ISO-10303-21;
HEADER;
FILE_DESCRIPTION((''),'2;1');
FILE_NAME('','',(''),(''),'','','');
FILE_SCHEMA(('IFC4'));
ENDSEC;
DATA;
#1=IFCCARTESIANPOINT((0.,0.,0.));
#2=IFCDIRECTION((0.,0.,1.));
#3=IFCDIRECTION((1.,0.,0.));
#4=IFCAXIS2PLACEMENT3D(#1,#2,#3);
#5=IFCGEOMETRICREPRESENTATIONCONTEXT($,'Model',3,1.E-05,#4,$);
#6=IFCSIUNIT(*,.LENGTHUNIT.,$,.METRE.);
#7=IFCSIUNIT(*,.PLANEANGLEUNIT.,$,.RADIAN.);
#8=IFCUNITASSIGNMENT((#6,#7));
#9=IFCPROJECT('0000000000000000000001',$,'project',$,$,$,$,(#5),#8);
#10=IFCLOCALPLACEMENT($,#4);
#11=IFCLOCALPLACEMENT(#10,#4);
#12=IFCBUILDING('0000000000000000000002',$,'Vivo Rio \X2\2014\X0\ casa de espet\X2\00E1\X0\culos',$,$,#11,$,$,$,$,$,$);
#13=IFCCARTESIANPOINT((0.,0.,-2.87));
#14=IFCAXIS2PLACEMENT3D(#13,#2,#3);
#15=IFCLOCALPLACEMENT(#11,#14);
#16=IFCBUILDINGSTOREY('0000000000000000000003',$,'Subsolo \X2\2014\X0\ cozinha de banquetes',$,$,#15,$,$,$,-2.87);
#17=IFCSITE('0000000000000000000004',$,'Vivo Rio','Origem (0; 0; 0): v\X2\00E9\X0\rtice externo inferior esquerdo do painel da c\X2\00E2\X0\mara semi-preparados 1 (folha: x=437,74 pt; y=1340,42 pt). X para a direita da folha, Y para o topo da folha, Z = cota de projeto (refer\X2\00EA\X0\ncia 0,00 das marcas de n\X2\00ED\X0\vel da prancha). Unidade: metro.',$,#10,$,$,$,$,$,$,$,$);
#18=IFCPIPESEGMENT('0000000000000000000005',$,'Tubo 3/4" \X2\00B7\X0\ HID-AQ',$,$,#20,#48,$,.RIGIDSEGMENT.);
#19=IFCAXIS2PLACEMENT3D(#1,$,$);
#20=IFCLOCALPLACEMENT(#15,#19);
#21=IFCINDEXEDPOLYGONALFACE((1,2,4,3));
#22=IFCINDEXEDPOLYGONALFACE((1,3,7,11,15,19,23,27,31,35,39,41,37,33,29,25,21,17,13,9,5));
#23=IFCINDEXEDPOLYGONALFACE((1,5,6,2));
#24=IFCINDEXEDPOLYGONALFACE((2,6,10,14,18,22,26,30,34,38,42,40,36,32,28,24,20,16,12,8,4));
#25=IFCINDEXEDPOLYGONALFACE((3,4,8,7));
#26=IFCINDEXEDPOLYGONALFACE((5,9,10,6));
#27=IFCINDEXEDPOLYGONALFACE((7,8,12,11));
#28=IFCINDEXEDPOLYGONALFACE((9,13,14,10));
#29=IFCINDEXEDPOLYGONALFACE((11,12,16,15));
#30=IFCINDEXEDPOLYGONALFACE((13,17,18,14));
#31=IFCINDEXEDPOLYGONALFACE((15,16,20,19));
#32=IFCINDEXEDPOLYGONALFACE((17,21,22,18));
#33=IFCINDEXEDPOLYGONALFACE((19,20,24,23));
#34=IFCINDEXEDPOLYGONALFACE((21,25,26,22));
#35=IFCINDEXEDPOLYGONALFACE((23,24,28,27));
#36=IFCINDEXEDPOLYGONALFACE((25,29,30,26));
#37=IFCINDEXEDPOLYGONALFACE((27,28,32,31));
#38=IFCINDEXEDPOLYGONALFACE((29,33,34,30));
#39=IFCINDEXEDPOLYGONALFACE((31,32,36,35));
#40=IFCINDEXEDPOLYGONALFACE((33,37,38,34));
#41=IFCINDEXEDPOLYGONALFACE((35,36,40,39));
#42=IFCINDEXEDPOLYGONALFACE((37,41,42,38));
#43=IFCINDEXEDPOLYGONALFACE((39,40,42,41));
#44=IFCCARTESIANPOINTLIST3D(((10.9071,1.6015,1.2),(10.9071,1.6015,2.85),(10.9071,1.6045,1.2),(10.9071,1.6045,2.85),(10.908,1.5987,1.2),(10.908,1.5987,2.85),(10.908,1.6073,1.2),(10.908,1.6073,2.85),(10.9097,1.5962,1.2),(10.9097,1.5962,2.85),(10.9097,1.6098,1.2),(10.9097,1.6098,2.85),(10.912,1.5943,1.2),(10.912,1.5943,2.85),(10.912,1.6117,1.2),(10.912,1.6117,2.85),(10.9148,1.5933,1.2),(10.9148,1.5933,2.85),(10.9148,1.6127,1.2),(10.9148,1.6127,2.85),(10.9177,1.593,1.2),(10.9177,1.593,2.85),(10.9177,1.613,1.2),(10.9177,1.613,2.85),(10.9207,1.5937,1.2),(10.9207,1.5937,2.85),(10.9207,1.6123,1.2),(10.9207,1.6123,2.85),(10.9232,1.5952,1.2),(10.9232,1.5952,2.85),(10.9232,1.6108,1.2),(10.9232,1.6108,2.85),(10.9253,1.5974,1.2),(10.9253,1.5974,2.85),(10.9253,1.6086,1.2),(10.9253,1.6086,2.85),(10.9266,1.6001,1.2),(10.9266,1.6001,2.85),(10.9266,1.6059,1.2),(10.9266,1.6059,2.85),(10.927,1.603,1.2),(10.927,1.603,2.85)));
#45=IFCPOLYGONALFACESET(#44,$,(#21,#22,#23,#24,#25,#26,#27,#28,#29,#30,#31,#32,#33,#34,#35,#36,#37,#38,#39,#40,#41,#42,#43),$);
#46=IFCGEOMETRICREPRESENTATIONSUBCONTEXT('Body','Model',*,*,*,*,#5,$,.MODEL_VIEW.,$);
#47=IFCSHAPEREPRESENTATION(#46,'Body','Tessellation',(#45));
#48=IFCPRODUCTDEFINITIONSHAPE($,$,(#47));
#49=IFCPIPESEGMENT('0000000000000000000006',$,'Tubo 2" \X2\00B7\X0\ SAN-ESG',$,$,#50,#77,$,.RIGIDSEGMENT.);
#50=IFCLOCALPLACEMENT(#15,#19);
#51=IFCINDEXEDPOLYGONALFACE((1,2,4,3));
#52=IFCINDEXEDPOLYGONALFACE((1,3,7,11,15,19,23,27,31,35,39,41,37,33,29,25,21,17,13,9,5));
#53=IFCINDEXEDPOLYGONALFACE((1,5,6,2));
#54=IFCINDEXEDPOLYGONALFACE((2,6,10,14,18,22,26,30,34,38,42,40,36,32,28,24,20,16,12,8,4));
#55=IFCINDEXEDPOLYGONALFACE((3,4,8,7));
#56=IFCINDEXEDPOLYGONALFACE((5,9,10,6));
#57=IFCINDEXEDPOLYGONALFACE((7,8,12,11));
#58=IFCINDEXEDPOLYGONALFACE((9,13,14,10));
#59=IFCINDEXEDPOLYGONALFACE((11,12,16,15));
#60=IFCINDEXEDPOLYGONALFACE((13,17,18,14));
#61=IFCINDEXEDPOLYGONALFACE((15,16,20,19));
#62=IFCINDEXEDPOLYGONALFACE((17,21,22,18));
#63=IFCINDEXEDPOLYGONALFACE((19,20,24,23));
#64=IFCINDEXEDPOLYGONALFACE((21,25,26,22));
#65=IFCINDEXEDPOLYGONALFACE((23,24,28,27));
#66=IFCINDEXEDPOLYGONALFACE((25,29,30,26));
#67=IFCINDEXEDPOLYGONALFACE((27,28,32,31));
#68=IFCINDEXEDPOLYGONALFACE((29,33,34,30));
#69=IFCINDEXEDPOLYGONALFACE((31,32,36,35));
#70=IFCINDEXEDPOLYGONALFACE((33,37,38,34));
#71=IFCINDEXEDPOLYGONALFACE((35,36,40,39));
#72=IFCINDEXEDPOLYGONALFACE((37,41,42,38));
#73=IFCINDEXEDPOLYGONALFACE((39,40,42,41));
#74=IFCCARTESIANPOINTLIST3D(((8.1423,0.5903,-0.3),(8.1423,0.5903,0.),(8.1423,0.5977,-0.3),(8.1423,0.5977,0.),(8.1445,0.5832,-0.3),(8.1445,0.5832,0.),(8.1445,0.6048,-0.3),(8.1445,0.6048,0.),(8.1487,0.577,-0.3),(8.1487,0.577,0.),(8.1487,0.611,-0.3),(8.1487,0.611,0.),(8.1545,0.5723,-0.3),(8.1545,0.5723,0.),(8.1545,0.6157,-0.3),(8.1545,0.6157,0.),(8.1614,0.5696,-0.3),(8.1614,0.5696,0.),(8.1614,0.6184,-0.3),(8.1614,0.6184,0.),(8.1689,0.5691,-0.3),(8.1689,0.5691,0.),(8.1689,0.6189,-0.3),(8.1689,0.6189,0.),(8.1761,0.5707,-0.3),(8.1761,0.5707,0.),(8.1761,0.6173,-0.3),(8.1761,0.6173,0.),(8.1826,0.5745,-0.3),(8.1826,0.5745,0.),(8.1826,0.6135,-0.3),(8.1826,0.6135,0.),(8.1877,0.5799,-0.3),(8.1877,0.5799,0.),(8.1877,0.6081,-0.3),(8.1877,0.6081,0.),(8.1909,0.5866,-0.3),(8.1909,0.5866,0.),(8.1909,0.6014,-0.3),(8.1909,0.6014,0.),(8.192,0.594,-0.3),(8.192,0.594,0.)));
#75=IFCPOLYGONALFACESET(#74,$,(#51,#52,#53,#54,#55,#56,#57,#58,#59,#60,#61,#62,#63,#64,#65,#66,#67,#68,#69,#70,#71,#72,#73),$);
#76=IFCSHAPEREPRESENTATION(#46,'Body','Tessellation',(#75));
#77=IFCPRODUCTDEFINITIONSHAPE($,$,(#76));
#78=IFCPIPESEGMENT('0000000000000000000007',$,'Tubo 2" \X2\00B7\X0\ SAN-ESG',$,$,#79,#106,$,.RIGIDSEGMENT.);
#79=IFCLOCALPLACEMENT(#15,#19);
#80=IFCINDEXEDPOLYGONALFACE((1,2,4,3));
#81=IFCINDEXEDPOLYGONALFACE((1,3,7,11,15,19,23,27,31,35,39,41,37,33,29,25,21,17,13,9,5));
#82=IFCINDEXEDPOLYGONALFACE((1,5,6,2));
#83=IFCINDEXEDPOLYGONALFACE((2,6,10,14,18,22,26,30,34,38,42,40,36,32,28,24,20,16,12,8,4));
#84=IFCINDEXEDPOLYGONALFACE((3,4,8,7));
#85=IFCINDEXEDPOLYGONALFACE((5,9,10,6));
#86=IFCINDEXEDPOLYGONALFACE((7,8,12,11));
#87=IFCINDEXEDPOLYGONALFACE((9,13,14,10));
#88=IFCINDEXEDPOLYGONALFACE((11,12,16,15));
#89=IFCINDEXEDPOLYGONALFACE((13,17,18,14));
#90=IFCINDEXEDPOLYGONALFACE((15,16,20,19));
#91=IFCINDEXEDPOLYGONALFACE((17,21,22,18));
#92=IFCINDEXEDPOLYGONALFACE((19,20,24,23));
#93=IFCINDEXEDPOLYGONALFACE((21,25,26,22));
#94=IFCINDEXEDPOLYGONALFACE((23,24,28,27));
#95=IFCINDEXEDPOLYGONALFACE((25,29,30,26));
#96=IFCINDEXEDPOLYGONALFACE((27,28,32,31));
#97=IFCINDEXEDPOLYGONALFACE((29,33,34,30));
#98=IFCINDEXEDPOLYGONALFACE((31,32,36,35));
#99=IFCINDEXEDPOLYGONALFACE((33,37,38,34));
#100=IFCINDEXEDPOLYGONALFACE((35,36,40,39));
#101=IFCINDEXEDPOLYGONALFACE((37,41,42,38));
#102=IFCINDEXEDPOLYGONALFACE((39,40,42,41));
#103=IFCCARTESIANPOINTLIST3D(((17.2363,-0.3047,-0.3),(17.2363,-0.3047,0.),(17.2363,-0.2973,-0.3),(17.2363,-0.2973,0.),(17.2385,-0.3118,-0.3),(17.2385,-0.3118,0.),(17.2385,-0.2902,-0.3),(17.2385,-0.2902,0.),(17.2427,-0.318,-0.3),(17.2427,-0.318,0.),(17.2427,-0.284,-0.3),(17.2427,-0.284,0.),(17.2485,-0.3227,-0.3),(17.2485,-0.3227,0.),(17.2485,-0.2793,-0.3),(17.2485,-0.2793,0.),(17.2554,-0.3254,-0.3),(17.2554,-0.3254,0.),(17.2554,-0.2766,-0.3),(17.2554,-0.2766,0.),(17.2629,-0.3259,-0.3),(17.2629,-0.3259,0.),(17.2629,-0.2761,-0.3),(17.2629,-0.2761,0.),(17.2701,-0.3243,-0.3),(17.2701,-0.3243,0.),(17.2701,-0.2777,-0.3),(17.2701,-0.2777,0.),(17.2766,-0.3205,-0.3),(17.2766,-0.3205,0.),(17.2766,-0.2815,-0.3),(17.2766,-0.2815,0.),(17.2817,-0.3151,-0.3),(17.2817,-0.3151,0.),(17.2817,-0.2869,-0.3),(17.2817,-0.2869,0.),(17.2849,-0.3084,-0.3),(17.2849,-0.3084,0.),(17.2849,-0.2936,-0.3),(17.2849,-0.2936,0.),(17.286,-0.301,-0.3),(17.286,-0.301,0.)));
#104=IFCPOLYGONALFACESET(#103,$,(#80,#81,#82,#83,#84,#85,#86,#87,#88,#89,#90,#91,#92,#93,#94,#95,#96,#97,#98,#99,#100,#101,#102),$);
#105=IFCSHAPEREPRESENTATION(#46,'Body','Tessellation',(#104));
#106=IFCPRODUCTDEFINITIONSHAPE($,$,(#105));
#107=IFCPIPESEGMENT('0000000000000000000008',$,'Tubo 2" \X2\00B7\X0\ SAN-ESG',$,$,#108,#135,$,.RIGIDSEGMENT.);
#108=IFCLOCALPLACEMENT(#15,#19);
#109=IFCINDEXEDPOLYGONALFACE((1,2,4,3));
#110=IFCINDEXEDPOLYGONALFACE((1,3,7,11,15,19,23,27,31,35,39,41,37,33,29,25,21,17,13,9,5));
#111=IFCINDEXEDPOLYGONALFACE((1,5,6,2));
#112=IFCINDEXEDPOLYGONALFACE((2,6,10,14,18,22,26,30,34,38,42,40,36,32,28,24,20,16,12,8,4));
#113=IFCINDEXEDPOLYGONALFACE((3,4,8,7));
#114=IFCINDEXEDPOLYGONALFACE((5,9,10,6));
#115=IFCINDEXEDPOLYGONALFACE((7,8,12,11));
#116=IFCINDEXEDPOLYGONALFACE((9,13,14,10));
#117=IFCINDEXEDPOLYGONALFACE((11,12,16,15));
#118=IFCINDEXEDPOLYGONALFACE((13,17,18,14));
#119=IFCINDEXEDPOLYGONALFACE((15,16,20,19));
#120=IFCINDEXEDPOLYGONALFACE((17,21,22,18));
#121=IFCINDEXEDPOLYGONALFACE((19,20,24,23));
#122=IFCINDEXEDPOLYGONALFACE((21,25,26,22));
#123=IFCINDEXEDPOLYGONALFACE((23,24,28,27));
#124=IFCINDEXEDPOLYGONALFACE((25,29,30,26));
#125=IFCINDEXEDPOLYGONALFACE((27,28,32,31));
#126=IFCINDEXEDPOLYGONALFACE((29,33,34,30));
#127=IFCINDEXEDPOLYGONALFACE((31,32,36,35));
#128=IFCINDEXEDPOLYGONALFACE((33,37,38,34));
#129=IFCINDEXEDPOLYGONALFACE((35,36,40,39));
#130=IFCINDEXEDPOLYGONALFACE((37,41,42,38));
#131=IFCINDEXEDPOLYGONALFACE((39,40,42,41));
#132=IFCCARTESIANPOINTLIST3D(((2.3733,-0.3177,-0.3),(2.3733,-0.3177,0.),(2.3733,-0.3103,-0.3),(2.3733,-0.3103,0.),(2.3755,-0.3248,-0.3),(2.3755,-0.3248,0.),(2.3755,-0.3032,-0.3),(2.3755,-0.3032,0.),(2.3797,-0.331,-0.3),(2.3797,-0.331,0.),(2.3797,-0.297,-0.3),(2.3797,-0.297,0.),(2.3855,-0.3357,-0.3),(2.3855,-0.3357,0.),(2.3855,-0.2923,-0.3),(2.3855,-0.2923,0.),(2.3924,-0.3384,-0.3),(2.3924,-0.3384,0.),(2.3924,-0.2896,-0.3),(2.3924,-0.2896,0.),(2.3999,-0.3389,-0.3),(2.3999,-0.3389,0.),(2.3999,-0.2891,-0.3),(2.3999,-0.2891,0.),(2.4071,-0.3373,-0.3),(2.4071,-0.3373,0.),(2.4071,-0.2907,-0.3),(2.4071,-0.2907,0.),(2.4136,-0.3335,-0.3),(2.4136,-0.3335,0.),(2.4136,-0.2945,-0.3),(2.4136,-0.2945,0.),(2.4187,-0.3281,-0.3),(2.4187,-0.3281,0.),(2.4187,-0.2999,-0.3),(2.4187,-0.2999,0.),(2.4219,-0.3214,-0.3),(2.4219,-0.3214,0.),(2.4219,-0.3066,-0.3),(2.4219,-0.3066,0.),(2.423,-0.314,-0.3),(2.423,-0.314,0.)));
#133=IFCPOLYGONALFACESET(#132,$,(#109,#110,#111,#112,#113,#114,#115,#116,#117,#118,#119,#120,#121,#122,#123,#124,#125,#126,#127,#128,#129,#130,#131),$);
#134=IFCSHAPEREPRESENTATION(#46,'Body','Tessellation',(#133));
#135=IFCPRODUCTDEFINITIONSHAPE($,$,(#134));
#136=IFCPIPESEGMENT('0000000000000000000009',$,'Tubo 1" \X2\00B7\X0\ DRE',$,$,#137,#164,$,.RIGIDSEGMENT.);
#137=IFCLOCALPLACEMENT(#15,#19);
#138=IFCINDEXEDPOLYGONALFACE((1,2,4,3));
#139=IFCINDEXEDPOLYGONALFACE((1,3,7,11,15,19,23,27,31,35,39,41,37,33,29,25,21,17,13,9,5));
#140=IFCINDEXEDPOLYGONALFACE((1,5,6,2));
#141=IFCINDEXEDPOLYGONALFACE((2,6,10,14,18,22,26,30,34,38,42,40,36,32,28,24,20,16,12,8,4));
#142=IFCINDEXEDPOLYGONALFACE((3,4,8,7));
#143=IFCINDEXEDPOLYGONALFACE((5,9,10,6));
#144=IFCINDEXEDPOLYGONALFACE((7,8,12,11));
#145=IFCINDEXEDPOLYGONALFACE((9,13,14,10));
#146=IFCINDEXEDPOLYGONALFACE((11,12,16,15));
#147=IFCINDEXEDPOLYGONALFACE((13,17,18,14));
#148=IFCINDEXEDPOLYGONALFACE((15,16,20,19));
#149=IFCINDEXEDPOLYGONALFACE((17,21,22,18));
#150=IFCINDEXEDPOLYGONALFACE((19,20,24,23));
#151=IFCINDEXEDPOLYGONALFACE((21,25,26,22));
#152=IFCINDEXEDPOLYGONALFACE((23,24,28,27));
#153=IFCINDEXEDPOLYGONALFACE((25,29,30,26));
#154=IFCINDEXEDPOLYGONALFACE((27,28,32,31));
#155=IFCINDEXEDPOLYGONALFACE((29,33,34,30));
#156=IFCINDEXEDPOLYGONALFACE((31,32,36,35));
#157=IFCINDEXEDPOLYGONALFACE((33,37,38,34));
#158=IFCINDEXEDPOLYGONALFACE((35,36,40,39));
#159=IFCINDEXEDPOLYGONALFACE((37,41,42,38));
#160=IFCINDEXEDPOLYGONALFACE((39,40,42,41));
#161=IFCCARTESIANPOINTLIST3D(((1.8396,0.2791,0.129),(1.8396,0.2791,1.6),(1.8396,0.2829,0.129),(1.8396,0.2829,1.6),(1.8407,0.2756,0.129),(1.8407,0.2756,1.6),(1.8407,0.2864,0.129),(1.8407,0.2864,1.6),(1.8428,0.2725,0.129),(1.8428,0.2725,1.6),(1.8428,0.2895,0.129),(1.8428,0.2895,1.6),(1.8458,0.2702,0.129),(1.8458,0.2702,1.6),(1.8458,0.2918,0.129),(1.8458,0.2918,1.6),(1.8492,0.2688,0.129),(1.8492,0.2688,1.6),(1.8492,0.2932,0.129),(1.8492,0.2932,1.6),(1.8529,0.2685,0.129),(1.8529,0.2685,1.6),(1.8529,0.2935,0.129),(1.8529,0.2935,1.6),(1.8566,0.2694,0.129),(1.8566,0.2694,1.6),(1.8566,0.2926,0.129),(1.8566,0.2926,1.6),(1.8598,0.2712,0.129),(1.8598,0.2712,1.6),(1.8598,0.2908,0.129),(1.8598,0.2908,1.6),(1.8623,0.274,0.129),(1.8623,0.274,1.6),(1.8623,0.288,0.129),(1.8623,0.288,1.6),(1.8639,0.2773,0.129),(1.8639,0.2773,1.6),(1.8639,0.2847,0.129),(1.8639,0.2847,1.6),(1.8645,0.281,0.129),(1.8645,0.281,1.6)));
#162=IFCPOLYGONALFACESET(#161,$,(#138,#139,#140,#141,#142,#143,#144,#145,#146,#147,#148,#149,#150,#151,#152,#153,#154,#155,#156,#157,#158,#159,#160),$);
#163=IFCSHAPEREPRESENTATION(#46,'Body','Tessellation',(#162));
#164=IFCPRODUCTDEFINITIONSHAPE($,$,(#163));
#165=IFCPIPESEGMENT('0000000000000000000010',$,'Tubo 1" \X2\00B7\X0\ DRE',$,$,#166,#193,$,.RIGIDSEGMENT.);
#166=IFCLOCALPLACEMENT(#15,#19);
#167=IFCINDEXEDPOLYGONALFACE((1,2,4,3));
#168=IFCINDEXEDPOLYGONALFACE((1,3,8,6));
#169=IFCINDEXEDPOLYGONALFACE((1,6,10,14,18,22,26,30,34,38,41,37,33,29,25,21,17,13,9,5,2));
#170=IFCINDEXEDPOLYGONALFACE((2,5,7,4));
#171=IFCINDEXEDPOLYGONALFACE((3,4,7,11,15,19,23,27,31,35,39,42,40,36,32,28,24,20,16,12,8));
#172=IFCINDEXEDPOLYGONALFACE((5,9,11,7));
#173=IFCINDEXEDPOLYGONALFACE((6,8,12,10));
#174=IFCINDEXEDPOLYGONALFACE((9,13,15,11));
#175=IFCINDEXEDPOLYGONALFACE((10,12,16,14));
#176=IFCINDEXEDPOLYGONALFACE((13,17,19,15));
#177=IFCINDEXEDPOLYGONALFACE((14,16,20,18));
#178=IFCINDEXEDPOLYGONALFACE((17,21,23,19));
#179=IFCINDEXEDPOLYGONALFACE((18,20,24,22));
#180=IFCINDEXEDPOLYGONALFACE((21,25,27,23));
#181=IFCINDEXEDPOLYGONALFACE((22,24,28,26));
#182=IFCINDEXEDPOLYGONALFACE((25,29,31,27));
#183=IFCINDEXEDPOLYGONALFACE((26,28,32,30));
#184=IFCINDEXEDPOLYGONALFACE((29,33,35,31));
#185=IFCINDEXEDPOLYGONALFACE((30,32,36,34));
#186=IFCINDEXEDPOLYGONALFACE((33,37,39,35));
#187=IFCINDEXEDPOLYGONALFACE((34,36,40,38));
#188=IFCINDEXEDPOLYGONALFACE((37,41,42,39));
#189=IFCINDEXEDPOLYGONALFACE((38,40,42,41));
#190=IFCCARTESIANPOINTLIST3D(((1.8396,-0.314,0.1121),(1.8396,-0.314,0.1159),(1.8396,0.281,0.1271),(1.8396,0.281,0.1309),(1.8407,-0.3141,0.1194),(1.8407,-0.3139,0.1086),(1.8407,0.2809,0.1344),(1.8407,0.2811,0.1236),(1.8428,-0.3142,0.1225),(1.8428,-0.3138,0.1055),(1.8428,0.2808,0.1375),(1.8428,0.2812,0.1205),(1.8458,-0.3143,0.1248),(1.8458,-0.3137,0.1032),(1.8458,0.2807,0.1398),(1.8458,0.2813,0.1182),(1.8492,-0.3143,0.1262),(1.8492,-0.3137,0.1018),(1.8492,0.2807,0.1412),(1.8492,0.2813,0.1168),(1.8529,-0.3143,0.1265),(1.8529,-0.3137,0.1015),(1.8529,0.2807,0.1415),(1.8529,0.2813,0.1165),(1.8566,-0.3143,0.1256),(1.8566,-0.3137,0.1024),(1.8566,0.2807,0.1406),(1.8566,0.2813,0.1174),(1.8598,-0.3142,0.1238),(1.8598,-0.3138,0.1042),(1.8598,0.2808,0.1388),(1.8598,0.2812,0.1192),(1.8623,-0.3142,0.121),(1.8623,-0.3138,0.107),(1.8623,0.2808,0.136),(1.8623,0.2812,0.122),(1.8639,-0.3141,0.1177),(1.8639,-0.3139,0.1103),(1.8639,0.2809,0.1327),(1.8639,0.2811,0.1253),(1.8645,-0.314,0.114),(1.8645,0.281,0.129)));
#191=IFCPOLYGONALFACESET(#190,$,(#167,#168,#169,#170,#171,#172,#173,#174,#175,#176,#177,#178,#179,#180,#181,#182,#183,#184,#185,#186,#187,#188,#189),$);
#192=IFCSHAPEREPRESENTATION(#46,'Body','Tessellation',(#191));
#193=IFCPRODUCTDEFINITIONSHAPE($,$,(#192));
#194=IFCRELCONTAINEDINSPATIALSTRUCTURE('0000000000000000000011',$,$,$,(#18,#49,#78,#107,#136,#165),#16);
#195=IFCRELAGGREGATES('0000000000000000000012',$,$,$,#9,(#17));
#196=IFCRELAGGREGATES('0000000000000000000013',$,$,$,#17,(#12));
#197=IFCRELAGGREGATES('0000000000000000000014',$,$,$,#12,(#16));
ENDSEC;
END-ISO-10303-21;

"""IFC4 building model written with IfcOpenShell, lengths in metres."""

from ifc_helpers import new_model, si_unit, frame, origin_with_axes, origin_2d, place, context, subcontext, project, spatial, circle, extrude, element, save


model = new_model("IFC4")

# Units and contexts
model_context = context("Model", 3, precision=1e-05, world=origin_with_axes())
body_context = subcontext(model_context, "Body", "Model", "MODEL_VIEW")
ifc_project = project(units=[si_unit("LENGTHUNIT", "METRE"), si_unit("PLANEANGLEUNIT", "RADIAN")], contexts=[model_context])

# Site, building, storey
site_placement = place(None, origin_with_axes())
site = spatial("IfcSite", under=ifc_project, at=site_placement, Name="Vivo Rio", Description="Origem (0; 0; 0): vértice externo inferior esquerdo do painel da câmara semi-preparados 1 (folha: x=437,74 pt; y=1340,42 pt). X para a direita da folha, Y para o topo da folha, Z = cota de projeto (referência 0,00 das marcas de nível da prancha). Unidade: metro.")
building_placement = place(site_placement, origin_with_axes())
building = spatial("IfcBuilding", under=site, at=building_placement, Name="Vivo Rio — casa de espetáculos")
storey_placement = place(building_placement, frame((0.0, 0.0, -2.87), z_axis=(0.0, 0.0, 1.0), x_axis=(1.0, 0.0, 0.0)))
storey = spatial("IfcBuildingStorey", under=building, at=storey_placement, Name="Subsolo — cozinha de banquetes", Elevation=-2.87)

# Pipe segments
pipe_segment_1_placement = place(storey_placement, origin_with_axes())
element("IfcPipeSegment", 1, at=pipe_segment_1_placement, inside=storey, Name="Tubo 3/4\" · HID-AQ", PredefinedType="RIGIDSEGMENT", context=body_context, shape_type="SweptSolid", body=[
    extrude(circle(Radius=0.01, at=origin_2d()), frame((10.917, 1.603, 2.85), z_axis=(0.0, 0.0, -1.0), x_axis=(1.0, 0.0, 0.0)), (0.0, 0.0, 1.0), 1.65),
])
pipe_segment_2_placement = place(storey_placement, origin_with_axes())
element("IfcPipeSegment", 2, at=pipe_segment_2_placement, inside=storey, Name="Tubo 2\" · SAN-ESG", PredefinedType="RIGIDSEGMENT", context=body_context, shape_type="SweptSolid", body=[
    extrude(circle(Radius=0.025, at=origin_2d()), frame((8.167, 0.594, 0.0), z_axis=(0.0, 0.0, -1.0), x_axis=(1.0, 0.0, 0.0)), (0.0, 0.0, 1.0), 0.3),
])
pipe_segment_3_placement = place(storey_placement, origin_with_axes())
element("IfcPipeSegment", 3, at=pipe_segment_3_placement, inside=storey, Name="Tubo 2\" · SAN-ESG", PredefinedType="RIGIDSEGMENT", context=body_context, shape_type="SweptSolid", body=[
    extrude(circle(Radius=0.025, at=origin_2d()), frame((17.261, -0.301, 0.0), z_axis=(0.0, 0.0, -1.0), x_axis=(1.0, 0.0, 0.0)), (0.0, 0.0, 1.0), 0.3),
])
pipe_segment_4_placement = place(storey_placement, origin_with_axes())
element("IfcPipeSegment", 4, at=pipe_segment_4_placement, inside=storey, Name="Tubo 2\" · SAN-ESG", PredefinedType="RIGIDSEGMENT", context=body_context, shape_type="SweptSolid", body=[
    extrude(circle(Radius=0.025, at=origin_2d()), frame((2.398, -0.314, 0.0), z_axis=(0.0, 0.0, -1.0), x_axis=(1.0, 0.0, 0.0)), (0.0, 0.0, 1.0), 0.3),
])
pipe_segment_5_placement = place(storey_placement, origin_with_axes())
element("IfcPipeSegment", 5, at=pipe_segment_5_placement, inside=storey, Name="Tubo 1\" · DRE", PredefinedType="RIGIDSEGMENT", context=body_context, shape_type="SweptSolid", body=[
    extrude(circle(Radius=0.0125, at=origin_2d()), frame((1.852, 0.281, 1.6), z_axis=(0.0, 0.0, -1.0), x_axis=(1.0, 0.0, 0.0)), (0.0, 0.0, 1.0), 1.471),
])
pipe_segment_6_placement = place(storey_placement, origin_with_axes())
element("IfcPipeSegment", 6, at=pipe_segment_6_placement, inside=storey, Name="Tubo 1\" · DRE", PredefinedType="RIGIDSEGMENT", context=body_context, shape_type="SweptSolid", body=[
    extrude(circle(Radius=0.0125, at=origin_2d()), frame((1.852, 0.281, 0.129), z_axis=(0.0, -0.999682, -0.025202), x_axis=(1.0, 0.0, 0.0)), (0.0, 0.0, 1.0), 0.5952),
])

save(model, "model.ifc")
